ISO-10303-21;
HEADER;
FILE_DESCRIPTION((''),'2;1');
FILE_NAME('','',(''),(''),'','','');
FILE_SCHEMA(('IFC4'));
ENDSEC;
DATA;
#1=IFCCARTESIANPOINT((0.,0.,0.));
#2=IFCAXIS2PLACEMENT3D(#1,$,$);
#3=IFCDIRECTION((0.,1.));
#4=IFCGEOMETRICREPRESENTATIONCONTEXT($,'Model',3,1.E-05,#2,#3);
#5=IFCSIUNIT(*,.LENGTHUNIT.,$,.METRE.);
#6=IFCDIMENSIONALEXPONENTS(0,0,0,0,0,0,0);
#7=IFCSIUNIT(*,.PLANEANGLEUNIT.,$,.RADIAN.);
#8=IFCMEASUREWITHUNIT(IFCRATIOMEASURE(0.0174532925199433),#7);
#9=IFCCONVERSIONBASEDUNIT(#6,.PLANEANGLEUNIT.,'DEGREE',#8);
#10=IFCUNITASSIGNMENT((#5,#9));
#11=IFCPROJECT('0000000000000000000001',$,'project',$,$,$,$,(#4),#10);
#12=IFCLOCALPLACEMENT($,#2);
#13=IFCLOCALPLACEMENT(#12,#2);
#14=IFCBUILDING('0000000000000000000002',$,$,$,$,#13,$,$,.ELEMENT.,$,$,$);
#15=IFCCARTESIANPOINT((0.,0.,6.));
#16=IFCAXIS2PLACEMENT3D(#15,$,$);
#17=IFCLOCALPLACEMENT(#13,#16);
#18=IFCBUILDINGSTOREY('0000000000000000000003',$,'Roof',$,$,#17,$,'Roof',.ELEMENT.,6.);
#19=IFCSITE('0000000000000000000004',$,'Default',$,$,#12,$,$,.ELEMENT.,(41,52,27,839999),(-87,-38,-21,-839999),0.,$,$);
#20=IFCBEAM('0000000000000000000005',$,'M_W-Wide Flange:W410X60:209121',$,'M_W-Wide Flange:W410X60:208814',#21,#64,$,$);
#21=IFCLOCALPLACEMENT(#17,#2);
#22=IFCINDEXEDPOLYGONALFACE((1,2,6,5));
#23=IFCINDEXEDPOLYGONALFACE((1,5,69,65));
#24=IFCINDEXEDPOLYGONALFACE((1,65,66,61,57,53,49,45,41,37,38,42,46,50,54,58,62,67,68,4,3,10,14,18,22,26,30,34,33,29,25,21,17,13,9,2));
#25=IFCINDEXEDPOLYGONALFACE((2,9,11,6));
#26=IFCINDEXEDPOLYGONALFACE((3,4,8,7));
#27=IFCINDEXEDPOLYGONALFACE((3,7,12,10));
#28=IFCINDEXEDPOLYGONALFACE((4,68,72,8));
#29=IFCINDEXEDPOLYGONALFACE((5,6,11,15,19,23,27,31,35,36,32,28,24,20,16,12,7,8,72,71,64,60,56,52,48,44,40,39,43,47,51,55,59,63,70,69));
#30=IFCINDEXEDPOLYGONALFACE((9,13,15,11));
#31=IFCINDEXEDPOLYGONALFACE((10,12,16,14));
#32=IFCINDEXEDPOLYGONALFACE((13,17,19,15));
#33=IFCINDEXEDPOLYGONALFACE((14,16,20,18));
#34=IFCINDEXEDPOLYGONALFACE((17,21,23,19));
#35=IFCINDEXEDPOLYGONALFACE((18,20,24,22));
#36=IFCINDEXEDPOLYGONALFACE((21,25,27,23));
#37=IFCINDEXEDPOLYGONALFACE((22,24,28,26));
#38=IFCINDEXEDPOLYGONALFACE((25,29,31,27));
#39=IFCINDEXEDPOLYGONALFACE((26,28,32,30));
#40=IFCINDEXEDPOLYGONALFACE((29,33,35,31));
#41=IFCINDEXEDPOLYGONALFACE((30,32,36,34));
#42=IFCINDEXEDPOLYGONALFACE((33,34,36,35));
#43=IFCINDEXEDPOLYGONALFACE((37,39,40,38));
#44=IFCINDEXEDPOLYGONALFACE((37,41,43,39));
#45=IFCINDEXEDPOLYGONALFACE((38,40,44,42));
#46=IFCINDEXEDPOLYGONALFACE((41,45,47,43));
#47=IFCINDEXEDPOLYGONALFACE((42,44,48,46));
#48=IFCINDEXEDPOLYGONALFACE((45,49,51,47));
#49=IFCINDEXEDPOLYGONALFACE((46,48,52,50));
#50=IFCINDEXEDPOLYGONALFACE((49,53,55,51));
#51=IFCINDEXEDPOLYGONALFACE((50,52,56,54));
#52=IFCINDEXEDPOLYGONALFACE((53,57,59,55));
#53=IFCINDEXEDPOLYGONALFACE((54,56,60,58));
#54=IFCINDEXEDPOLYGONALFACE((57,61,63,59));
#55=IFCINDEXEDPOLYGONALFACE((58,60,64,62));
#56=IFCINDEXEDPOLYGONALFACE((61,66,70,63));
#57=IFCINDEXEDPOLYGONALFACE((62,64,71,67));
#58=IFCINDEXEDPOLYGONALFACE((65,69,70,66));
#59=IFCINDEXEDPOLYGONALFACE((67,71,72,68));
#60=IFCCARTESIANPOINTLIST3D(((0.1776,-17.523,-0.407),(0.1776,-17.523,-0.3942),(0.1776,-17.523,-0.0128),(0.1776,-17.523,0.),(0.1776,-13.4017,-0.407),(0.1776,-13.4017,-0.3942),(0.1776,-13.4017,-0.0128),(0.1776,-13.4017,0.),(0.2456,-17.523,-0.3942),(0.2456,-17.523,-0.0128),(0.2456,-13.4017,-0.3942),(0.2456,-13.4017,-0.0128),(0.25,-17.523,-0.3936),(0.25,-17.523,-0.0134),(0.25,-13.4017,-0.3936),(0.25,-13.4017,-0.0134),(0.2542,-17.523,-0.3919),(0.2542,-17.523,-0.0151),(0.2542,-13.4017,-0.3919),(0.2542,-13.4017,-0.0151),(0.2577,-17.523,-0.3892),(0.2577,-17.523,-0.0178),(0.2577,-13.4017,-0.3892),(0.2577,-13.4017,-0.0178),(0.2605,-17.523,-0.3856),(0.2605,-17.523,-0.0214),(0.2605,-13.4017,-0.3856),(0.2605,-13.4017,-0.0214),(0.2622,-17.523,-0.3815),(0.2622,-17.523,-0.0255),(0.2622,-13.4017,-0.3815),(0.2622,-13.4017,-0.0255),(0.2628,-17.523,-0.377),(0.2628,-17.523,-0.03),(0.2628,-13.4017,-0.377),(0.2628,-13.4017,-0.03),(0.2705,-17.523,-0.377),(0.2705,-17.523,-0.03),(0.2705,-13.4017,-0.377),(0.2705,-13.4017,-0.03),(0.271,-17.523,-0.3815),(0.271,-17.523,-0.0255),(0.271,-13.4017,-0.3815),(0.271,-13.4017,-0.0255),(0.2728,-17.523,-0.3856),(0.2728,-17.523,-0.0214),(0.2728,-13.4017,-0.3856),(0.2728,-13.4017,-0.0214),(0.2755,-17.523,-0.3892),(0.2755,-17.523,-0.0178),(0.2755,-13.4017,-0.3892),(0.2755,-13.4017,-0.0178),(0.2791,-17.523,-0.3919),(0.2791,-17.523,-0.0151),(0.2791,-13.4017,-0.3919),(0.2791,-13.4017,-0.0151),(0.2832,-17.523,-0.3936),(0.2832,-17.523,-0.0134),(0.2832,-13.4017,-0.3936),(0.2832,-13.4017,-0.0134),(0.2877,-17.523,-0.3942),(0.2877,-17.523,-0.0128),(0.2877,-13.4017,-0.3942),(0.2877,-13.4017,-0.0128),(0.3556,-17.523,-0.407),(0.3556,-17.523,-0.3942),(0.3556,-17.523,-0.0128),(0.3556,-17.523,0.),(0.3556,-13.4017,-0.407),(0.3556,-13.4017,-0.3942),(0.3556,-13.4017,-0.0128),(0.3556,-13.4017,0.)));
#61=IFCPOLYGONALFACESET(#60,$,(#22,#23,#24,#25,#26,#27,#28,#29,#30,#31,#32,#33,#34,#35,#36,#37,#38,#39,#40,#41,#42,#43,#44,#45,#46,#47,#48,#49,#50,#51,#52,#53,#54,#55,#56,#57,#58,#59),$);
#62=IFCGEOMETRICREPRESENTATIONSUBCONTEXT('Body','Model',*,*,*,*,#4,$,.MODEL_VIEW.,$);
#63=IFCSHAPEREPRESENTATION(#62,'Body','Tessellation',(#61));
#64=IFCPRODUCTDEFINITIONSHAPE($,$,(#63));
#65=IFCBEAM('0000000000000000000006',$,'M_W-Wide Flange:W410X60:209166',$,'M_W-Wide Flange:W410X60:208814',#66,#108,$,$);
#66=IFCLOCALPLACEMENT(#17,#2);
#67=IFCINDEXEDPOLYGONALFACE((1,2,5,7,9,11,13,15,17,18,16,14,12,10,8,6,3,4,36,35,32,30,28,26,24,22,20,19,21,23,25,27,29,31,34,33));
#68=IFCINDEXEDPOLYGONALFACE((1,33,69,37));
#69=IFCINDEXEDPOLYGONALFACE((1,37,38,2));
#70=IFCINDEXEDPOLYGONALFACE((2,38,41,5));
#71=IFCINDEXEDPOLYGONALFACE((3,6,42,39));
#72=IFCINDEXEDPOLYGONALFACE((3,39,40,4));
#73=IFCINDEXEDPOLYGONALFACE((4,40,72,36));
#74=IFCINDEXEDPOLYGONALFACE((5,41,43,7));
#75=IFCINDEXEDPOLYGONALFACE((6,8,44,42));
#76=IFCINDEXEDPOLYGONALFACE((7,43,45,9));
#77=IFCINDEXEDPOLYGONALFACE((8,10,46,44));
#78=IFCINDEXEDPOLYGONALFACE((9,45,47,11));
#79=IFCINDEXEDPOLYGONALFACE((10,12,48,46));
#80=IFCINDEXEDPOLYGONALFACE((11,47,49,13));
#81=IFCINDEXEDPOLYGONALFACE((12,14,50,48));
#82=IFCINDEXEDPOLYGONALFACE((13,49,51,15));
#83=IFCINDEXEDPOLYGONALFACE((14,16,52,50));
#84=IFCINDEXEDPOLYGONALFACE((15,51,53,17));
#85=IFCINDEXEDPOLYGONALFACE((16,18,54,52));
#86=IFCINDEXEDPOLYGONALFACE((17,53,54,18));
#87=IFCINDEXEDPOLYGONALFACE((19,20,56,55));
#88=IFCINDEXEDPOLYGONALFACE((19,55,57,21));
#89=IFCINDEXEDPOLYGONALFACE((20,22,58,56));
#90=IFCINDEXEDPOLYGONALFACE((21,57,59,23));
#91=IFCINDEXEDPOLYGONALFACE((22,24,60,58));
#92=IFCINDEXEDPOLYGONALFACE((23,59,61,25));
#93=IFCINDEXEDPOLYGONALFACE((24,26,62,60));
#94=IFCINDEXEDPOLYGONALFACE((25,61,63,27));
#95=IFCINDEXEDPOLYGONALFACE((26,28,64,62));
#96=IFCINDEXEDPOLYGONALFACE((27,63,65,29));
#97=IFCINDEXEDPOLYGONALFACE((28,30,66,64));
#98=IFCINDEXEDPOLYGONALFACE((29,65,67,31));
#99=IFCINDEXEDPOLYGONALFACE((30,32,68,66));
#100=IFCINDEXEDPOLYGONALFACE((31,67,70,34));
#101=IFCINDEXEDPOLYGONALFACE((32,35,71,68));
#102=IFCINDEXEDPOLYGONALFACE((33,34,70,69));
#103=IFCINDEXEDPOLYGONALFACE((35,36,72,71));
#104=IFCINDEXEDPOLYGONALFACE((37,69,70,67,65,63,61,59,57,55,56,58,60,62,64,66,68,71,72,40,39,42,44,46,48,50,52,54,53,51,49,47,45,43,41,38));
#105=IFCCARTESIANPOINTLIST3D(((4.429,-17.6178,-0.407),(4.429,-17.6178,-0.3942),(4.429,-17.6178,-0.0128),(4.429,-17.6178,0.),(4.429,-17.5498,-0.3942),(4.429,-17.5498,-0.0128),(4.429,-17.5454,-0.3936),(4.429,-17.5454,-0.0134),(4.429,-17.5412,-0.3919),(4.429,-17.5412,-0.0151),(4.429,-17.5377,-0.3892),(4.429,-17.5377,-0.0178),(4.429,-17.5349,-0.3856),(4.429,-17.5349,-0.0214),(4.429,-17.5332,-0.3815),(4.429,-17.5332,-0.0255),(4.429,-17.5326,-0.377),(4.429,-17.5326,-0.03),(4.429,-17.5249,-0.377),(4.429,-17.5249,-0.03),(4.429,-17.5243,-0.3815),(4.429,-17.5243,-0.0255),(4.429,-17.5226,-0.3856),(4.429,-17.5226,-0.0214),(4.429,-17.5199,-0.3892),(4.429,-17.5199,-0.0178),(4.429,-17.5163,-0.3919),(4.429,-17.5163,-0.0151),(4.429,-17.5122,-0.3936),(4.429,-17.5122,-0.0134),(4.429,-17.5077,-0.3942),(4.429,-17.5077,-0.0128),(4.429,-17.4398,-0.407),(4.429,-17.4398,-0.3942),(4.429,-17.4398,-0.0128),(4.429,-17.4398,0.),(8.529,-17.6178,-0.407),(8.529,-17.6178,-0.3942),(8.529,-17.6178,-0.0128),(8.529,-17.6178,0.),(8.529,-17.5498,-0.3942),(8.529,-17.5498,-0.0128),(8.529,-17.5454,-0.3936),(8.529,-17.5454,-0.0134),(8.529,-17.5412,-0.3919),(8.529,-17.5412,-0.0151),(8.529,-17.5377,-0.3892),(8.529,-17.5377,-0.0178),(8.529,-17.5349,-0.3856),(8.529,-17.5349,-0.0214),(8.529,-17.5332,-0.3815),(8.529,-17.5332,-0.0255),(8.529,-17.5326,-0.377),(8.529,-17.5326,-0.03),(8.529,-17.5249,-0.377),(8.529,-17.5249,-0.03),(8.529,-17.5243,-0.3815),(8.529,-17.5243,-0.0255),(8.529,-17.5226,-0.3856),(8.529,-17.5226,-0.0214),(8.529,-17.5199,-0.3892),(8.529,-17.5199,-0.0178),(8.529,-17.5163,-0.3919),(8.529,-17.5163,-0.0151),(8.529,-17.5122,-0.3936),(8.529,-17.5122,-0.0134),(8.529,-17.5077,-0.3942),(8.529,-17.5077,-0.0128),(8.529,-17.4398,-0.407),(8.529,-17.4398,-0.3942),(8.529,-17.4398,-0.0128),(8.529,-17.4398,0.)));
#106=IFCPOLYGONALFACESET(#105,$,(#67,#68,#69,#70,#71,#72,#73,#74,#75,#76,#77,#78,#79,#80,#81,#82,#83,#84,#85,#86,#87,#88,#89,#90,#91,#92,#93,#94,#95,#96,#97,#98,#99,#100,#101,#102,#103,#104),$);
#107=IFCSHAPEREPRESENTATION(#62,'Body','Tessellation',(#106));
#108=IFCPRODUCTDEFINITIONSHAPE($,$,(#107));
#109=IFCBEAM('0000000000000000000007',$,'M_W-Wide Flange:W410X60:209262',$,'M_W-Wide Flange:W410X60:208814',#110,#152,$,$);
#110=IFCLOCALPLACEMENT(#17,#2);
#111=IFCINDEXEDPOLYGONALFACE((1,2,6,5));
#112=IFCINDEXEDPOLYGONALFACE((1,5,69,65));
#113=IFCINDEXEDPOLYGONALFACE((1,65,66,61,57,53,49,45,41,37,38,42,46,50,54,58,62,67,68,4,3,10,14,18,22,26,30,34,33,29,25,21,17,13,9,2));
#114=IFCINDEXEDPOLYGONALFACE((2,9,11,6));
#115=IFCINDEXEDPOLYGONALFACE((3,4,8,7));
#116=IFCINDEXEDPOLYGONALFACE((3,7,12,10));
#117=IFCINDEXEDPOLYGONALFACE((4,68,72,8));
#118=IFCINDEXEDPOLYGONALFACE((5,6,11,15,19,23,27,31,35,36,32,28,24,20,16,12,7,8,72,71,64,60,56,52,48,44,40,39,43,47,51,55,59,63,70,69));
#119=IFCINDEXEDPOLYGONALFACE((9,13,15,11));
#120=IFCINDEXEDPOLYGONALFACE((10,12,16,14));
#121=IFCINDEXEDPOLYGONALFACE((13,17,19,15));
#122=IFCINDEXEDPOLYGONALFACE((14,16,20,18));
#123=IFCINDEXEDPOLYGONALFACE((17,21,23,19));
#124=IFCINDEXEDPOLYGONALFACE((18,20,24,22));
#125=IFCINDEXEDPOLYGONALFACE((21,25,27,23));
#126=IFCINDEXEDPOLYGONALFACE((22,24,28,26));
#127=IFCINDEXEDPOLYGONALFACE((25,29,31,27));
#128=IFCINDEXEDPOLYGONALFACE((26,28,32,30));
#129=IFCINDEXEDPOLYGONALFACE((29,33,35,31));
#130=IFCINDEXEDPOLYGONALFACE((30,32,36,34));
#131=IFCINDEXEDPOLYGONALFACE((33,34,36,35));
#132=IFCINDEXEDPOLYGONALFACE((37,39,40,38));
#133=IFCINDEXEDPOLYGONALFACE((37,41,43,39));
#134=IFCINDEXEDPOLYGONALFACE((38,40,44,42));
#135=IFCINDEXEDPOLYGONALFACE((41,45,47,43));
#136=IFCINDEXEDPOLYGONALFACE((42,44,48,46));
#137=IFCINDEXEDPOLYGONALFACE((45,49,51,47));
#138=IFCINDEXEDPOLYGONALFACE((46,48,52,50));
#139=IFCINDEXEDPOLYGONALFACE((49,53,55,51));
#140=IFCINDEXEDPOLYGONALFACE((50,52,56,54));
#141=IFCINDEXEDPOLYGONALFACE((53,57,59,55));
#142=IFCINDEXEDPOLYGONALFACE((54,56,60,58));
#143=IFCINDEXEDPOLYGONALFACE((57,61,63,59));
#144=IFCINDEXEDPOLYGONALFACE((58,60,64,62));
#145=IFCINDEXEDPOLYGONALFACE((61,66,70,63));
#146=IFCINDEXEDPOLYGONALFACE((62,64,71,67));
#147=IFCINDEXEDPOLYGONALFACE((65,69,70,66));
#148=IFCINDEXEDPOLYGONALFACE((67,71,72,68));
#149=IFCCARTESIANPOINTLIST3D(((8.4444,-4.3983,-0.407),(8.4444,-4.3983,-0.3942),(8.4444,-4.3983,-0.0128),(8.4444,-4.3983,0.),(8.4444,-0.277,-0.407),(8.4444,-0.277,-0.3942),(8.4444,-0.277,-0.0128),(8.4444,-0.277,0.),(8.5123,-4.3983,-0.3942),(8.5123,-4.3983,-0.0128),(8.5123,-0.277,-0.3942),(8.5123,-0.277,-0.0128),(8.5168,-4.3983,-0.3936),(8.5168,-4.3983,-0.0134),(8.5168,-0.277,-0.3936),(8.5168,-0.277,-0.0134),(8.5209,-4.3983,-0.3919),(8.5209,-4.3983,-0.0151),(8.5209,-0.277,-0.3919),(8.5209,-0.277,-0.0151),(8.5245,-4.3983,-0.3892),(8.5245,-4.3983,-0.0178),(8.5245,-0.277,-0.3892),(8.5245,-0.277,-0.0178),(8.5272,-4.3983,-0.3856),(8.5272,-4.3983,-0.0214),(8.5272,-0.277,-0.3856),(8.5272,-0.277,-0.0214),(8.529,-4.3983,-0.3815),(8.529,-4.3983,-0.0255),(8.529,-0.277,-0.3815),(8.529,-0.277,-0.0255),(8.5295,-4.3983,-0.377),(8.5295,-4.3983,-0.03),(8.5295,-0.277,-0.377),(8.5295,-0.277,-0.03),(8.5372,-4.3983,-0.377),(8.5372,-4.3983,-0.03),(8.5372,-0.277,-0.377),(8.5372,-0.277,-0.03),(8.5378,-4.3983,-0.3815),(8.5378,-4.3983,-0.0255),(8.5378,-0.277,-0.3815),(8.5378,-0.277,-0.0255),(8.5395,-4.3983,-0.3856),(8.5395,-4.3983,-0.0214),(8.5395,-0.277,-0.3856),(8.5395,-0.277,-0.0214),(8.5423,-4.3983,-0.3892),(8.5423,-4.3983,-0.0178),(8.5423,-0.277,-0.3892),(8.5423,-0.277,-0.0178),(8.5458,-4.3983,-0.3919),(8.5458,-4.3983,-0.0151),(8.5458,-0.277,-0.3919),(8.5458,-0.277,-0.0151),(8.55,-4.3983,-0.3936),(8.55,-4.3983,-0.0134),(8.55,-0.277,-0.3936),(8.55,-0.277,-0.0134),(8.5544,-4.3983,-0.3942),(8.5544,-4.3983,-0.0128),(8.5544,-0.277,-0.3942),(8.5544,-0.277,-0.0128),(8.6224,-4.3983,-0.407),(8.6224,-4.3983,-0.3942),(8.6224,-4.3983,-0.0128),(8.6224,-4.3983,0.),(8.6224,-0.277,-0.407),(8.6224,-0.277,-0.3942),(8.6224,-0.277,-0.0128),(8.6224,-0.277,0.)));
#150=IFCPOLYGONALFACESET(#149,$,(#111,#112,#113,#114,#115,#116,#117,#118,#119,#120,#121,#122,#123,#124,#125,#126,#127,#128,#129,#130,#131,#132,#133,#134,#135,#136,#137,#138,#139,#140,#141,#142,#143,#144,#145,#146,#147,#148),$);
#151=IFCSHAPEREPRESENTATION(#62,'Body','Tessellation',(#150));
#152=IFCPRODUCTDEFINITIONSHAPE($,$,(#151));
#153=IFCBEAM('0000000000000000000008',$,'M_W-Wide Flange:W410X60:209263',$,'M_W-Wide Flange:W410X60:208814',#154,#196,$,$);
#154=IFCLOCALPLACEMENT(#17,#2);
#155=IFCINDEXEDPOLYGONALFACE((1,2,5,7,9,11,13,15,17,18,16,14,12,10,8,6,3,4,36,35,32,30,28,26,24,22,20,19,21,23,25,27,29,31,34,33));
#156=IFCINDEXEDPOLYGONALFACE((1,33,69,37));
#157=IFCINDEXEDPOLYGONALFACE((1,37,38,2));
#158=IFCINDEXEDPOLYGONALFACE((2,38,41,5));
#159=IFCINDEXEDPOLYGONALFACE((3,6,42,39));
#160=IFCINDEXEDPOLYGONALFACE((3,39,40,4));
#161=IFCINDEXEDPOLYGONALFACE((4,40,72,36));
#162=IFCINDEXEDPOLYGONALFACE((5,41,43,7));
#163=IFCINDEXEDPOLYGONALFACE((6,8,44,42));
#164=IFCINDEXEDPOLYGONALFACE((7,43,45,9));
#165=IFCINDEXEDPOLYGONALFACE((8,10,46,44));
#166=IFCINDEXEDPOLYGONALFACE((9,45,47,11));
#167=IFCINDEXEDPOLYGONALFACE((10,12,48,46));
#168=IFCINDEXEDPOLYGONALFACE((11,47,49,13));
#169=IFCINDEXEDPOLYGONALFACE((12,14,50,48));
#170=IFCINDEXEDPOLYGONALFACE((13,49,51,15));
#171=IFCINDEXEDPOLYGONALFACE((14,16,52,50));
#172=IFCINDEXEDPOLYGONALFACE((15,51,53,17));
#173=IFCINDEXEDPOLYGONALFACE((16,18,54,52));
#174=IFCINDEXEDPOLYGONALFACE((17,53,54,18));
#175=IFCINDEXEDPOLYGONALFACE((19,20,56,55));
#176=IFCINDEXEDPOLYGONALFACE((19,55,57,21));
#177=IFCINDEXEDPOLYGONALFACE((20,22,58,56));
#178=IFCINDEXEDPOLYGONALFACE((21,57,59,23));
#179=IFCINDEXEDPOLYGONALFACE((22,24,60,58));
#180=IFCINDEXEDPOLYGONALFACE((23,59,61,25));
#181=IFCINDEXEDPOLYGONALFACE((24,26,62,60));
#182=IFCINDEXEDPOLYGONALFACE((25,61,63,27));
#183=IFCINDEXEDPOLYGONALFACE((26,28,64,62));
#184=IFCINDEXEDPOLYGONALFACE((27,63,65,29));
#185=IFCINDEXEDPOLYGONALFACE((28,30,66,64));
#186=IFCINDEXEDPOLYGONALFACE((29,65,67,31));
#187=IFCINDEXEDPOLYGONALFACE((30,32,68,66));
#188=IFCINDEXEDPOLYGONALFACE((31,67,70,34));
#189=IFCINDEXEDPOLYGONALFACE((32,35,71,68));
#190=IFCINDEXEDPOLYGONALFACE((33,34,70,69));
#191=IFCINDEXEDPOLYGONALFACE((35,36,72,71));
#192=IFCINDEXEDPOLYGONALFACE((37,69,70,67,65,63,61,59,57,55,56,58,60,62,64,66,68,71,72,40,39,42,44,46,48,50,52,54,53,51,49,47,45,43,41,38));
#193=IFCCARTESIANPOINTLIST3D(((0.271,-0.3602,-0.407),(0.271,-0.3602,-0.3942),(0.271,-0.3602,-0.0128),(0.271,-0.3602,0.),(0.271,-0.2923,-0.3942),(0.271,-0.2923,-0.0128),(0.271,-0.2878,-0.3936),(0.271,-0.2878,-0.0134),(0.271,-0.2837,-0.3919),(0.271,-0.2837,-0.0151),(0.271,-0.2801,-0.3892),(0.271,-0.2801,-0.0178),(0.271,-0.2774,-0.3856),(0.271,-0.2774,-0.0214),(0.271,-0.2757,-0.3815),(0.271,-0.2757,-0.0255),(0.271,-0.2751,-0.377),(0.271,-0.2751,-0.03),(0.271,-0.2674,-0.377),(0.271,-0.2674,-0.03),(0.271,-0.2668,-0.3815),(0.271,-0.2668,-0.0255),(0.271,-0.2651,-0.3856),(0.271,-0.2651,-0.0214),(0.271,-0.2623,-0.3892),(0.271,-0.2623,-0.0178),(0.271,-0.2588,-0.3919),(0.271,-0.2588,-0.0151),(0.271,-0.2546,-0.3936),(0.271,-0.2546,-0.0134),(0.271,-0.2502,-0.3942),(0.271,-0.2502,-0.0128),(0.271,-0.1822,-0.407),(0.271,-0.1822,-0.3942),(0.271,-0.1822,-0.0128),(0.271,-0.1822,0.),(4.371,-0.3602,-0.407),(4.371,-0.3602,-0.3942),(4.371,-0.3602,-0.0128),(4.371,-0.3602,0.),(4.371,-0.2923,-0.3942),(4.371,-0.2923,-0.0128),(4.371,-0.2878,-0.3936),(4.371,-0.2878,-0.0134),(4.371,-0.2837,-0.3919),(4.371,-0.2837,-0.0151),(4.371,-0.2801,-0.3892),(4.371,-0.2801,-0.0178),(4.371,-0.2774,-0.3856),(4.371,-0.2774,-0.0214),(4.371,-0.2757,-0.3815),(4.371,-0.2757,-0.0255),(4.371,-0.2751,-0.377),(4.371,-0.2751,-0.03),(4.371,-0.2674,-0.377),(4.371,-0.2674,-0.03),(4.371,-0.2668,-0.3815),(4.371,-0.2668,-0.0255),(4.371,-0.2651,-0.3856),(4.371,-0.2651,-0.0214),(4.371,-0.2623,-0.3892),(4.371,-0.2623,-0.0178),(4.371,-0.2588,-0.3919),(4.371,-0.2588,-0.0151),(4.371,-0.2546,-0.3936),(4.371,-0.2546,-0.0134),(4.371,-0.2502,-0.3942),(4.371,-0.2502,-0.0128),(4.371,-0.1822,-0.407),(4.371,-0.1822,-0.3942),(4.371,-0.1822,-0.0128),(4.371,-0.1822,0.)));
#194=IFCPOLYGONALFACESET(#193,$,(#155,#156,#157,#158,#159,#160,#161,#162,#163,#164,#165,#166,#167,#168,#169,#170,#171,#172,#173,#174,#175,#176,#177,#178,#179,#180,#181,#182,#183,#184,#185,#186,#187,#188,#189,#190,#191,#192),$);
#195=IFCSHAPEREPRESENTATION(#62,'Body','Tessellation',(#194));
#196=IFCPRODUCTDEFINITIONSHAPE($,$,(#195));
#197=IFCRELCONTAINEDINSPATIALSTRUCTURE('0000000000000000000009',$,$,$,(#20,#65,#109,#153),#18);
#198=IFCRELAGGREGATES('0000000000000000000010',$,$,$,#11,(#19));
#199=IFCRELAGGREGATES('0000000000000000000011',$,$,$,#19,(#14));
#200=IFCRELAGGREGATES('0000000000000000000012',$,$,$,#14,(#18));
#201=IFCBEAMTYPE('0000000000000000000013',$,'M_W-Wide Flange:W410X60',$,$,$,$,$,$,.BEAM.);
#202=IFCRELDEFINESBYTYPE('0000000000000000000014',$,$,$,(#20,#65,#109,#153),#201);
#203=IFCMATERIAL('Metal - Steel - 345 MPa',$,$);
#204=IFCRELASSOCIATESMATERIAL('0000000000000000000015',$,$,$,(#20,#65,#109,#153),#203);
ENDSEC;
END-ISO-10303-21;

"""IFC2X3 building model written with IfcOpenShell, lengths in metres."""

from ifc_helpers import new_model, entity, si_unit, converted_unit, direction, frame, frame_2d, origin, place, context, subcontext, project, spatial, i_section, extrude, material, type_object, element, save


model = new_model("IFC2X3")

# Units and contexts
model_context = context("Model", 3, precision=1e-05, world=origin(), true_north=direction((0.0, 1.0)))
body_context = subcontext(model_context, "Body", "Model", "MODEL_VIEW")
ifc_project = project(units=[si_unit("LENGTHUNIT", "METRE"), converted_unit("PLANEANGLEUNIT", "DEGREE", entity("IfcRatioMeasure", 0.0174532925199433), si_unit("PLANEANGLEUNIT", "RADIAN"), dimensions=[0, 0, 0, 0, 0, 0, 0])], contexts=[model_context])

# Site, building, storey
site_placement = place(None, origin())
site = spatial("IfcSite", under=ifc_project, at=site_placement, Name="Default", CompositionType="ELEMENT", RefLatitude=(41, 52, 27, 839999), RefLongitude=(-87, -38, -21, -839999), RefElevation=0.0)
building_placement = place(site_placement, origin())
building = spatial("IfcBuilding", under=site, at=building_placement, CompositionType="ELEMENT")
storey_placement = place(building_placement, frame((0.0, 0.0, 6.0)))
storey = spatial("IfcBuildingStorey", under=building, at=storey_placement, Name="Roof", LongName="Roof", CompositionType="ELEMENT", Elevation=6.0)

# Beams
ifc_material_1 = material(Name="Metal - Steel - 345 MPa")
beam_type = type_object("IfcBeamType", Name="M_W-Wide Flange:W410X60", PredefinedType="BEAM")
beam_1_placement = place(storey_placement, frame((0.2666, -13.4017, 0.0), z_axis=(0.0, 0.0, 1.0), x_axis=(0.0, -1.0, 0.0)))
element("IfcBeam", 1, at=beam_1_placement, inside=storey, type_object=beam_type, material=ifc_material_1, Name="M_W-Wide Flange:W410X60:209121", ObjectType="M_W-Wide Flange:W410X60:208814", context=body_context, shape_type="SweptSolid", body=[
    extrude(i_section(OverallWidth=0.178, OverallDepth=0.407, WebThickness=0.0077, FlangeThickness=0.0128, FilletRadius=0.0172, at=frame_2d((0.0, 0.0), x_axis=(0.0, 1.0))), frame((0.0, 0.0, -0.2035), z_axis=(1.0, 0.0, 0.0), x_axis=(0.0, 0.0, -1.0)), (0.0, 0.0, 1.0), 4.1213),
])
beam_2_placement = place(storey_placement, frame((4.429, -17.5288, 0.0)))
element("IfcBeam", 2, at=beam_2_placement, inside=storey, type_object=beam_type, material=ifc_material_1, Name="M_W-Wide Flange:W410X60:209166", ObjectType="M_W-Wide Flange:W410X60:208814", context=body_context, shape_type="SweptSolid", body=[
    extrude(i_section(OverallWidth=0.178, OverallDepth=0.407, WebThickness=0.0077, FlangeThickness=0.0128, FilletRadius=0.0172, at=frame_2d((0.0, 0.0), x_axis=(0.0, 1.0))), frame((0.0, 0.0, -0.2035), z_axis=(1.0, 0.0, 0.0), x_axis=(0.0, 0.0, -1.0)), (0.0, 0.0, 1.0), 4.1),
])
beam_3_placement = place(storey_placement, frame((8.5334, -4.3983, 0.0), z_axis=(0.0, 0.0, 1.0), x_axis=(0.0, 1.0, 0.0)))
element("IfcBeam", 3, at=beam_3_placement, inside=storey, type_object=beam_type, material=ifc_material_1, Name="M_W-Wide Flange:W410X60:209262", ObjectType="M_W-Wide Flange:W410X60:208814", context=body_context, shape_type="SweptSolid", body=[
    extrude(i_section(OverallWidth=0.178, OverallDepth=0.407, WebThickness=0.0077, FlangeThickness=0.0128, FilletRadius=0.0172, at=frame_2d((0.0, 0.0), x_axis=(0.0, 1.0))), frame((0.0, 0.0, -0.2035), z_axis=(1.0, 0.0, 0.0), x_axis=(0.0, 0.0, -1.0)), (0.0, 0.0, 1.0), 4.1213),
])
beam_4_placement = place(storey_placement, frame((4.371, -0.2712, 0.0), z_axis=(0.0, 0.0, 1.0), x_axis=(-1.0, 0.0, 0.0)))
element("IfcBeam", 4, at=beam_4_placement, inside=storey, type_object=beam_type, material=ifc_material_1, Name="M_W-Wide Flange:W410X60:209263", ObjectType="M_W-Wide Flange:W410X60:208814", context=body_context, shape_type="SweptSolid", body=[
    extrude(i_section(OverallWidth=0.178, OverallDepth=0.407, WebThickness=0.0077, FlangeThickness=0.0128, FilletRadius=0.0172, at=frame_2d((0.0, 0.0), x_axis=(0.0, 1.0))), frame((0.0, 0.0, -0.2035), z_axis=(1.0, 0.0, 0.0), x_axis=(0.0, 0.0, -1.0)), (0.0, 0.0, 1.0), 4.1),
])

save(model, "model.ifc")
